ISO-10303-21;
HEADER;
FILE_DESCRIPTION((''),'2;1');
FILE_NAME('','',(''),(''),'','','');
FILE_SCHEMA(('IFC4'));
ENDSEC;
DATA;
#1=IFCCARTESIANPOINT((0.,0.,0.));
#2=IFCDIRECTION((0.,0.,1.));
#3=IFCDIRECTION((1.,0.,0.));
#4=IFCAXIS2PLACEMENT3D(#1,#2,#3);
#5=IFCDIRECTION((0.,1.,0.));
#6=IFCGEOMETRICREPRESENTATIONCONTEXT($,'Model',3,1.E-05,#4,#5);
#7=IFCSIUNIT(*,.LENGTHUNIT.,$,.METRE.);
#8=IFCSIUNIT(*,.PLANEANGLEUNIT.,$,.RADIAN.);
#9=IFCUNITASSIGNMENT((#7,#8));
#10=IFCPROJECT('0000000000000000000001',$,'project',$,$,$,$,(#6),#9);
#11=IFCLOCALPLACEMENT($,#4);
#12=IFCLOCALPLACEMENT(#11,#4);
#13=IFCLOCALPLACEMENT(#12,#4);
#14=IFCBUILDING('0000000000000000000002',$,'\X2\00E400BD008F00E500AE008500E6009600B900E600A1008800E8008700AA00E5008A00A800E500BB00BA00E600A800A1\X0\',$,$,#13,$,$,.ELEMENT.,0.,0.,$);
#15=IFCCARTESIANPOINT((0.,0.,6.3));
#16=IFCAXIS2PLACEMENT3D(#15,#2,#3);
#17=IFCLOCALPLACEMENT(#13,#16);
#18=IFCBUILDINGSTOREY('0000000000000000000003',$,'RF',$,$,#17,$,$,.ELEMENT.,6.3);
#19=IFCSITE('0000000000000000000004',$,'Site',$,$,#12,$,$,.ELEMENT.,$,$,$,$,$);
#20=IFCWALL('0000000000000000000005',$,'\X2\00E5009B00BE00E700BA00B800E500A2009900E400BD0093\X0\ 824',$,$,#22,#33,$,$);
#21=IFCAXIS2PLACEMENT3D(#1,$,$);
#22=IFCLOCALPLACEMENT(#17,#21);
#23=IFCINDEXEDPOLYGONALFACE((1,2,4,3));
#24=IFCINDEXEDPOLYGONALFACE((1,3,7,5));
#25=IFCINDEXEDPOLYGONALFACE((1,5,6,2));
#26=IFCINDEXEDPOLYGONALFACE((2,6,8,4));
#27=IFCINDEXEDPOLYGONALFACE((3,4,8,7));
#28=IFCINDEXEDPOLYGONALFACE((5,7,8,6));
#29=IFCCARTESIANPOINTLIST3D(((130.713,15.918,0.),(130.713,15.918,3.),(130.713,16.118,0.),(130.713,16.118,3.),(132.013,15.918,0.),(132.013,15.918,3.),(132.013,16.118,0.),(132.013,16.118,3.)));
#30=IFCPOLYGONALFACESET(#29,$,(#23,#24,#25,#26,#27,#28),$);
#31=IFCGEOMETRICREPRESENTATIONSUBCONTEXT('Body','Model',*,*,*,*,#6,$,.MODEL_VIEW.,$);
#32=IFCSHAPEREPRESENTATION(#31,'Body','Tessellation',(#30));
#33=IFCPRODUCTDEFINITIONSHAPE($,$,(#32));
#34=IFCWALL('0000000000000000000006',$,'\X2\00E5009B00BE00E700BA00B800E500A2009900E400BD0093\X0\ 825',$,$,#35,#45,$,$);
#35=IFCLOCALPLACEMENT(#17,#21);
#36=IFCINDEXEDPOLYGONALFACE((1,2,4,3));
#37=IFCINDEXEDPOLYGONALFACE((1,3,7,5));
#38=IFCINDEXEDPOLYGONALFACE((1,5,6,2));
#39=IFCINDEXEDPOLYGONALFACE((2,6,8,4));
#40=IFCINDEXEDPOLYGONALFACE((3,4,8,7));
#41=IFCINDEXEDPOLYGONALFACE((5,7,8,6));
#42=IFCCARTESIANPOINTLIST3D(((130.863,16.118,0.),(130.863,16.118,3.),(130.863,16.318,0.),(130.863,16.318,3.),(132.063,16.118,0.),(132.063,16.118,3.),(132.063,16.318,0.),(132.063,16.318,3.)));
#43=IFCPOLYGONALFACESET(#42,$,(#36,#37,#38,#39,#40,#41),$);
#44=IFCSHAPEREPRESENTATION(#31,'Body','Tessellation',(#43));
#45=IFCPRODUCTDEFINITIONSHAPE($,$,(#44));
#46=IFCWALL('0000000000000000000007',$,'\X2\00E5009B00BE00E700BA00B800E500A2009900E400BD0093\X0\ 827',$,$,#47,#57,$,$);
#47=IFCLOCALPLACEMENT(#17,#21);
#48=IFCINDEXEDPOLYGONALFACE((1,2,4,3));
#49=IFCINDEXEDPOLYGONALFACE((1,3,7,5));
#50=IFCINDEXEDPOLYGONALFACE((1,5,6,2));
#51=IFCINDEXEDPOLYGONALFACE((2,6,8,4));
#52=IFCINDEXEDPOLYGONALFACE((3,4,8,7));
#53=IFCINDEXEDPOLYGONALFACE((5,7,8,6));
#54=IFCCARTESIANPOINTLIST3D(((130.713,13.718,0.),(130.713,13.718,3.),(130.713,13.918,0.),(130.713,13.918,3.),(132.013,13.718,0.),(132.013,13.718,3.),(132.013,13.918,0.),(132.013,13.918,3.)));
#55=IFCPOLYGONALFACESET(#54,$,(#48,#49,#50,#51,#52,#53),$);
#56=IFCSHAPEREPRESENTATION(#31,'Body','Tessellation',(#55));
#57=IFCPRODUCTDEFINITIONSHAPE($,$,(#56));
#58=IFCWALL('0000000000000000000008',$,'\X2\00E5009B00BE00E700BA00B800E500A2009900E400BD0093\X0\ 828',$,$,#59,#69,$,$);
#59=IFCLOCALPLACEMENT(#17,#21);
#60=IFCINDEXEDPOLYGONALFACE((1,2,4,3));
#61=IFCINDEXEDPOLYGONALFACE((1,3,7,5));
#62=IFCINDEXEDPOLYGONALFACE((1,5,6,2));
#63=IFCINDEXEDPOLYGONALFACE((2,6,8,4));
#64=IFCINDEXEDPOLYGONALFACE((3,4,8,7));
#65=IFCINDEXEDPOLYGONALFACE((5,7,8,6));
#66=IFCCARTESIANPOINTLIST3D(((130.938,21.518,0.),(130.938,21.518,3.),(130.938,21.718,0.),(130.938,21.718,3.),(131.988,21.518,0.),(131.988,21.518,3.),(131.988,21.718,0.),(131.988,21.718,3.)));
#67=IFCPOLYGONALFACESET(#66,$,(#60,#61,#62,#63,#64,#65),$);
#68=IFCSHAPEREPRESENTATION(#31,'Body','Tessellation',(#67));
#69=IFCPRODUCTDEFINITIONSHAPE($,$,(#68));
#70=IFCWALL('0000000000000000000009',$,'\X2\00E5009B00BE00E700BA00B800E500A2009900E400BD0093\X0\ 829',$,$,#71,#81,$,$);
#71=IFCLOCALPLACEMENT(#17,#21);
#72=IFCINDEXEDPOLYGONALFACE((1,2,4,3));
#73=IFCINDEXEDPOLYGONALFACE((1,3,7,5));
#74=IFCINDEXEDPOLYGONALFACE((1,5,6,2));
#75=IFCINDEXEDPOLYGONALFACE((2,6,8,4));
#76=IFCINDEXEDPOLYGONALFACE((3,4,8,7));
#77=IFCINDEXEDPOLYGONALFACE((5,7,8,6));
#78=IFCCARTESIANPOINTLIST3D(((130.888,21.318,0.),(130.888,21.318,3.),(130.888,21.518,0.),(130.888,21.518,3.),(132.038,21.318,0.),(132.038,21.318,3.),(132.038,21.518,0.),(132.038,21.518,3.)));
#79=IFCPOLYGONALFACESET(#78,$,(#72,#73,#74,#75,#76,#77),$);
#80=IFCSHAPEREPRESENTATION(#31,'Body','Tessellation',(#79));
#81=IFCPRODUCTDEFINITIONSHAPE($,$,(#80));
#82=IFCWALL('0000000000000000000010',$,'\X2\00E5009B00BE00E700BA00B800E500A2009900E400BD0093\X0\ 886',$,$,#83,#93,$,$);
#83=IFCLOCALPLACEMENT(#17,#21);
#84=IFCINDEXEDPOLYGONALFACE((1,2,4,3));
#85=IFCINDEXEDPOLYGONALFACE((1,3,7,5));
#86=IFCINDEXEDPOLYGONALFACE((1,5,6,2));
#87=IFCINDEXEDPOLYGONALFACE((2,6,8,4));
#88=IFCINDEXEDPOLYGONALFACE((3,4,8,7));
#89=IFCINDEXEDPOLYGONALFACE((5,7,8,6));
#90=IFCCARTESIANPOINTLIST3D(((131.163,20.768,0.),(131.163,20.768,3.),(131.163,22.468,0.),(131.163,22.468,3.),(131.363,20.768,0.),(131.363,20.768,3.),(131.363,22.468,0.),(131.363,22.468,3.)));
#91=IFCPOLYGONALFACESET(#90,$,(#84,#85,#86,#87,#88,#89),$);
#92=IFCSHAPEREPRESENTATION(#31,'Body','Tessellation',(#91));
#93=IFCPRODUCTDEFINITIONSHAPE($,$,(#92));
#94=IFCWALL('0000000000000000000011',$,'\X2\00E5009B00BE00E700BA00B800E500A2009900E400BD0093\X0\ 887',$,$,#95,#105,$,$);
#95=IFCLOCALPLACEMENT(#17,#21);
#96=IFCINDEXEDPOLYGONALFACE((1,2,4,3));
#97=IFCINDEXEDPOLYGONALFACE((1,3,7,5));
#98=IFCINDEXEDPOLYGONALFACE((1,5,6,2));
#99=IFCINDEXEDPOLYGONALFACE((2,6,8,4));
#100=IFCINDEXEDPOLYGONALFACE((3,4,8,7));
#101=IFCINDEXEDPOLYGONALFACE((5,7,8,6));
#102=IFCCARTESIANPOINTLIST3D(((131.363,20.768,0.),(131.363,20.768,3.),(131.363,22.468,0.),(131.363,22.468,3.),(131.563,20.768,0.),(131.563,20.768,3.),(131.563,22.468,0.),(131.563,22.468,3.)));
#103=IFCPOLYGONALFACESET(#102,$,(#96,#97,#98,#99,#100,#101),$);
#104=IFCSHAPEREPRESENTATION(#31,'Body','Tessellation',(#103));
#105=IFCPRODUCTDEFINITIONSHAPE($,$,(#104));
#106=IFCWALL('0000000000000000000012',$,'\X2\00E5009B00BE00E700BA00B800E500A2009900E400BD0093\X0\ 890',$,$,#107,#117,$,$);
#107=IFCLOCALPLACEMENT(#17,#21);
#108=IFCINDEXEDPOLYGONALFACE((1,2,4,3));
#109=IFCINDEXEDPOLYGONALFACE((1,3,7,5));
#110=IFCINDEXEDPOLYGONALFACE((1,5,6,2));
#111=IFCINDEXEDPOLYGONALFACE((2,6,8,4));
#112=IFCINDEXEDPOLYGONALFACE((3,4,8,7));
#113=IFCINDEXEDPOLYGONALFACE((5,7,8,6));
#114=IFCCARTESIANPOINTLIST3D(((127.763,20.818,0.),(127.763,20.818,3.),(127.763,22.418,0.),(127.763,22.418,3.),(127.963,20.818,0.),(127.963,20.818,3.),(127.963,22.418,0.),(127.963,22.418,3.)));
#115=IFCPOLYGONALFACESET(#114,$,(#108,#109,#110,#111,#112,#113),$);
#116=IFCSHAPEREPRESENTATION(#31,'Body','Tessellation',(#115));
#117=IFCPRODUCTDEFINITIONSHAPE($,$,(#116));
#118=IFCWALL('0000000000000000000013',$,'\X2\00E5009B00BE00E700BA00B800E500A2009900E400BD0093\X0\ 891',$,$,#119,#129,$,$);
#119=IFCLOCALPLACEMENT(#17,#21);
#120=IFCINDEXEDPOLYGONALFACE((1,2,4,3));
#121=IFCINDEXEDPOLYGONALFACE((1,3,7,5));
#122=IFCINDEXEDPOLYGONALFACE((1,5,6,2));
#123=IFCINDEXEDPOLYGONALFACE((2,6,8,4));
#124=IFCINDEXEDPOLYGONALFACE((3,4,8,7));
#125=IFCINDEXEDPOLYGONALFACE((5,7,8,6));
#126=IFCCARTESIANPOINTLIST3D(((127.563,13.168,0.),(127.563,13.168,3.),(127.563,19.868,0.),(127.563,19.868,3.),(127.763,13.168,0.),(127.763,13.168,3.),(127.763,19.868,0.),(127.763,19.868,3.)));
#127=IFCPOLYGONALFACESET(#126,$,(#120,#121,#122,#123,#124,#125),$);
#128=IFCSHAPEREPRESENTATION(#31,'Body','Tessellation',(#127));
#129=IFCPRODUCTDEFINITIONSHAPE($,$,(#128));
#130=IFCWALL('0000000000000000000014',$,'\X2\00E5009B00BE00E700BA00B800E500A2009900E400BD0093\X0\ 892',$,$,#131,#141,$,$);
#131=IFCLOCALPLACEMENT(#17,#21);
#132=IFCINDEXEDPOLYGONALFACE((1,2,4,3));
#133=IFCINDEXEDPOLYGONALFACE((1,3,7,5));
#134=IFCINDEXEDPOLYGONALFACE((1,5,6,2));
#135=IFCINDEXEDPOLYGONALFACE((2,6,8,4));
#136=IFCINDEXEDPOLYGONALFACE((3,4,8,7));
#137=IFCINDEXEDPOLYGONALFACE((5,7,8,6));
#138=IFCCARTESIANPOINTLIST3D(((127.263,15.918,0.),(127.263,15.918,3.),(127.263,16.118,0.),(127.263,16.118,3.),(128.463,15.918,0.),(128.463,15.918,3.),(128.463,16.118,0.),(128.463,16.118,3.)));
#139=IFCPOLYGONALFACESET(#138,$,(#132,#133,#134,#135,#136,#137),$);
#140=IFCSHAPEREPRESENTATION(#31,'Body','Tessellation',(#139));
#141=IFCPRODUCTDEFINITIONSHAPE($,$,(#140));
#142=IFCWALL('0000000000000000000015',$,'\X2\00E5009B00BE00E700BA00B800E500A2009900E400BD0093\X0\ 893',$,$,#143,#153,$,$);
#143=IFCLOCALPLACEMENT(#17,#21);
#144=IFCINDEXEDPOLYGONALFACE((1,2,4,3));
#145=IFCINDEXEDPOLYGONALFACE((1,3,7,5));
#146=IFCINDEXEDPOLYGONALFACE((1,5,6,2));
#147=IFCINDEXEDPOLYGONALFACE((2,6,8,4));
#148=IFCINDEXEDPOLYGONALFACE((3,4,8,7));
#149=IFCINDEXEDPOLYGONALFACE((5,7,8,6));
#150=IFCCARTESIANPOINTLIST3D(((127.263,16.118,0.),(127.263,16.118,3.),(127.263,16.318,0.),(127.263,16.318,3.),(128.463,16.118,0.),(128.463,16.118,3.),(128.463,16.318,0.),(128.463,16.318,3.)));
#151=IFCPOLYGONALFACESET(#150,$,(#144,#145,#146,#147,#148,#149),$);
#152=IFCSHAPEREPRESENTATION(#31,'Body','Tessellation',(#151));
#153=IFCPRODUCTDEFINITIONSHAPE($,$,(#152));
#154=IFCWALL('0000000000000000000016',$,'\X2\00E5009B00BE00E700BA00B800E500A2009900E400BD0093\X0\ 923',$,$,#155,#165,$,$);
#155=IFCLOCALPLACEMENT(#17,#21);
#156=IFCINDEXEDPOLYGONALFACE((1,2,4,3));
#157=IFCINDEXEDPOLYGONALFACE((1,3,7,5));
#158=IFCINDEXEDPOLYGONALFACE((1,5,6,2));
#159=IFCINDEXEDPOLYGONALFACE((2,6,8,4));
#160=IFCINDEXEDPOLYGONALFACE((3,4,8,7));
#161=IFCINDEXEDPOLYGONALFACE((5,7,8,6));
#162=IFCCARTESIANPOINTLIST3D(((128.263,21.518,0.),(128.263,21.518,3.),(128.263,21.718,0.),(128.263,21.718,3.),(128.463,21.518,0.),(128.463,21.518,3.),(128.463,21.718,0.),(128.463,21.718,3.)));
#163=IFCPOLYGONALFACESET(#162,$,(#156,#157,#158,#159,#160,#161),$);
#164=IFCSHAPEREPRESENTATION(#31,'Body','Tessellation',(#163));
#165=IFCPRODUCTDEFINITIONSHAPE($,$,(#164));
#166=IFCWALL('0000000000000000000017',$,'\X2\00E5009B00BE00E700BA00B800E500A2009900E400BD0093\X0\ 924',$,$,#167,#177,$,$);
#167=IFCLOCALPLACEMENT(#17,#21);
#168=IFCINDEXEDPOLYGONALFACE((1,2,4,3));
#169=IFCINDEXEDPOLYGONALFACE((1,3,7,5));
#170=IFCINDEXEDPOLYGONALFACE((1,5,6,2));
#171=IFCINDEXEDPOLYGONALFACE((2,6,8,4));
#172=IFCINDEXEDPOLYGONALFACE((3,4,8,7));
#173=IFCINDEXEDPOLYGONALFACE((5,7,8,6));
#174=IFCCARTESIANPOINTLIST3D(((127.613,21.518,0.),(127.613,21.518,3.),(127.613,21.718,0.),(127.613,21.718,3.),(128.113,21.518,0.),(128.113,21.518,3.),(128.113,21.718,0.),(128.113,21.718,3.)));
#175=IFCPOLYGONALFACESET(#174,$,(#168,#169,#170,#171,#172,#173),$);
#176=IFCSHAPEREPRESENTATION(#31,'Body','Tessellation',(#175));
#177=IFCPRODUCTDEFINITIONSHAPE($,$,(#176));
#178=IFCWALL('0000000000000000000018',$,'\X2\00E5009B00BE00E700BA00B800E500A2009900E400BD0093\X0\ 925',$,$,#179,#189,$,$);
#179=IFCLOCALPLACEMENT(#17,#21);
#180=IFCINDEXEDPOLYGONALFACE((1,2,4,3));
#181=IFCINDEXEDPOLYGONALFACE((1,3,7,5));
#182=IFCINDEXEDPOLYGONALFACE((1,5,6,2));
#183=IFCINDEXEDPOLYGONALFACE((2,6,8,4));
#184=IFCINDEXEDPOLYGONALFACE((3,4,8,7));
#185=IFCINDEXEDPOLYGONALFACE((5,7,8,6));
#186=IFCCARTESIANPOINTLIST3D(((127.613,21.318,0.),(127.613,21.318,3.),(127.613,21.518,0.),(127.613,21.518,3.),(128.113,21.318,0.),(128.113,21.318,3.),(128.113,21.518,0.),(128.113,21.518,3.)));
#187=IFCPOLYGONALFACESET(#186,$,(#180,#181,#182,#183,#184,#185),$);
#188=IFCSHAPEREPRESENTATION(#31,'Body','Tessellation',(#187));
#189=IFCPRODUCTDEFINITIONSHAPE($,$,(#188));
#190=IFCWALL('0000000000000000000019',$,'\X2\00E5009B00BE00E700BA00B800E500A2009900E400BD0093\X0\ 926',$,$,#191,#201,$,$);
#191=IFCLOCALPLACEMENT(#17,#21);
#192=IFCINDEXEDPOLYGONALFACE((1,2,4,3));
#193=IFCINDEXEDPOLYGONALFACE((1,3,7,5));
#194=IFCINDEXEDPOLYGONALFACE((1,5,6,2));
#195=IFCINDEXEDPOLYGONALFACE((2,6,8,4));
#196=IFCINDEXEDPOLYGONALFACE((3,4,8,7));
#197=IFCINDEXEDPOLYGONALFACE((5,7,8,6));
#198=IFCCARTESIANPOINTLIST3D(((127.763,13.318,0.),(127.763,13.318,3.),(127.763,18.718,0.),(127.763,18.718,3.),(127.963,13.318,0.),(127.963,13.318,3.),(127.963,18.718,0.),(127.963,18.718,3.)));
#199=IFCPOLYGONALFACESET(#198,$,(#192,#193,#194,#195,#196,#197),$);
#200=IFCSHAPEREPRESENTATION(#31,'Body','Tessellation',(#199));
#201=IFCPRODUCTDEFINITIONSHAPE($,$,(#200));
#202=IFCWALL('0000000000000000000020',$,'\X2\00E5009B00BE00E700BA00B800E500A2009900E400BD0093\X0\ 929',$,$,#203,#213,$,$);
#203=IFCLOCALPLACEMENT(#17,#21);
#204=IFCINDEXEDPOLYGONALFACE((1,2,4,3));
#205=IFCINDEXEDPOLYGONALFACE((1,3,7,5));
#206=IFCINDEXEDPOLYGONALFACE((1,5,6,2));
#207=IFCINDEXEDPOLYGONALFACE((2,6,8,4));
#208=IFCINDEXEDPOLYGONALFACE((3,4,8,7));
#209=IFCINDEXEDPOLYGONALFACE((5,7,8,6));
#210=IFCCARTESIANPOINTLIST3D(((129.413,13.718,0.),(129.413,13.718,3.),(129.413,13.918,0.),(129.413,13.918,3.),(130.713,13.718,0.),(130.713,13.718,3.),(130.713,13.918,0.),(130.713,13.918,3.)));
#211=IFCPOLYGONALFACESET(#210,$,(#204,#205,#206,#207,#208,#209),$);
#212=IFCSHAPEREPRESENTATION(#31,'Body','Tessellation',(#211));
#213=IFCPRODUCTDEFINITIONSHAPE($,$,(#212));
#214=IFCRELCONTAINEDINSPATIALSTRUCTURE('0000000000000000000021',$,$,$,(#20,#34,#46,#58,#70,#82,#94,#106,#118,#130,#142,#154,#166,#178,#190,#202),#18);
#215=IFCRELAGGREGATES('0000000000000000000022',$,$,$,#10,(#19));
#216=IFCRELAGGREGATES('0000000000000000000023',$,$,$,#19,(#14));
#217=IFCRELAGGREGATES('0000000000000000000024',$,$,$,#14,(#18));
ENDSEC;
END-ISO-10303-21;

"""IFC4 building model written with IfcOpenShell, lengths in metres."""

from ifc_helpers import new_model, si_unit, direction, frame, frame_2d, origin_with_axes, place, context, subcontext, project, spatial, rectangle, extrude, element, save


model = new_model("IFC4")

# Units and contexts
model_context = context("Model", 3, precision=1e-05, world=origin_with_axes(), true_north=direction((0.0, 1.0, 0.0)))
body_context = subcontext(model_context, "Body", "Model", "MODEL_VIEW")
ifc_project = project(units=[si_unit("LENGTHUNIT", "METRE"), si_unit("PLANEANGLEUNIT", "RADIAN")], contexts=[model_context])

# Site, building, storey
placement = place(None, origin_with_axes())
site_placement = place(placement, origin_with_axes())
site = spatial("IfcSite", under=ifc_project, at=site_placement, Name="Site", CompositionType="ELEMENT")
building_placement = place(site_placement, origin_with_axes())
building = spatial("IfcBuilding", under=site, at=building_placement, Name="ä½\u008få®\u0085æ\u0096¹æ¡\u0088è\u0087ªå\u008a¨å»ºæ¨¡", CompositionType="ELEMENT", ElevationOfRefHeight=0.0, ElevationOfTerrain=0.0)
storey_placement = place(building_placement, frame((0.0, 0.0, 6.3), z_axis=(0.0, 0.0, 1.0), x_axis=(1.0, 0.0, 0.0)))
storey = spatial("IfcBuildingStorey", under=building, at=storey_placement, Name="RF", CompositionType="ELEMENT", Elevation=6.3)

# Walls
wall_1_placement = place(storey_placement, frame((131.363, 16.018, 0.0), z_axis=(0.0, 0.0, 1.0), x_axis=(1.0, 0.0, 0.0)))
element("IfcWall", 1, at=wall_1_placement, inside=storey, Name="å\u009b¾çº¸å¢\u0099ä½\u0093 824", context=body_context, shape_type="SweptSolid", body=[
    extrude(rectangle(XDim=1.3, YDim=0.2, at=frame_2d((0.0, 0.0), x_axis=(1.0, 0.0, 0.0))), frame((0.0, 0.0, 0.0), z_axis=(0.0, 0.0, 1.0)), (0.0, 0.0, 1.0), 3.0),
])
wall_2_placement = place(storey_placement, frame((131.463, 16.218, 0.0), z_axis=(0.0, 0.0, 1.0), x_axis=(1.0, 0.0, 0.0)))
element("IfcWall", 2, at=wall_2_placement, inside=storey, Name="å\u009b¾çº¸å¢\u0099ä½\u0093 825", context=body_context, shape_type="SweptSolid", body=[
    extrude(rectangle(XDim=1.2, YDim=0.2, at=frame_2d((0.0, 0.0), x_axis=(1.0, 0.0, 0.0))), frame((0.0, 0.0, 0.0), z_axis=(0.0, 0.0, 1.0)), (0.0, 0.0, 1.0), 3.0),
])
wall_3_placement = place(storey_placement, frame((131.363, 13.818, 0.0), z_axis=(0.0, 0.0, 1.0), x_axis=(1.0, 0.0, 0.0)))
element("IfcWall", 3, at=wall_3_placement, inside=storey, Name="å\u009b¾çº¸å¢\u0099ä½\u0093 827", context=body_context, shape_type="SweptSolid", body=[
    extrude(rectangle(XDim=1.3, YDim=0.2, at=frame_2d((0.0, 0.0), x_axis=(1.0, 0.0, 0.0))), frame((0.0, 0.0, 0.0), z_axis=(0.0, 0.0, 1.0)), (0.0, 0.0, 1.0), 3.0),
])
wall_4_placement = place(storey_placement, frame((131.463, 21.618, 0.0), z_axis=(0.0, 0.0, 1.0), x_axis=(1.0, 0.0, 0.0)))
element("IfcWall", 4, at=wall_4_placement, inside=storey, Name="å\u009b¾çº¸å¢\u0099ä½\u0093 828", context=body_context, shape_type="SweptSolid", body=[
    extrude(rectangle(XDim=1.05, YDim=0.2, at=frame_2d((0.0, 0.0), x_axis=(1.0, 0.0, 0.0))), frame((0.0, 0.0, 0.0), z_axis=(0.0, 0.0, 1.0)), (0.0, 0.0, 1.0), 3.0),
])
wall_5_placement = place(storey_placement, frame((131.463, 21.418, 0.0), z_axis=(0.0, 0.0, 1.0), x_axis=(1.0, 0.0, 0.0)))
element("IfcWall", 5, at=wall_5_placement, inside=storey, Name="å\u009b¾çº¸å¢\u0099ä½\u0093 829", context=body_context, shape_type="SweptSolid", body=[
    extrude(rectangle(XDim=1.15, YDim=0.2, at=frame_2d((0.0, 0.0), x_axis=(1.0, 0.0, 0.0))), frame((0.0, 0.0, 0.0), z_axis=(0.0, 0.0, 1.0)), (0.0, 0.0, 1.0), 3.0),
])
for number, where, z_axis, x_axis, name in (
    (6, (131.263, 21.618, 0.0), (0.0, 0.0, 1.0), (0.0, 1.0, 0.0), "å\u009b¾çº¸å¢\u0099ä½\u0093 886"),
    (7, (131.463, 21.618, 0.0), (0.0, 0.0, 1.0), (0.0, 1.0, 0.0), "å\u009b¾çº¸å¢\u0099ä½\u0093 887"),
):
    element("IfcWall", number, at=place(storey_placement, frame(where, z_axis=z_axis, x_axis=x_axis)), inside=storey, Name=name, context=body_context, shape_type="SweptSolid", body=[
        extrude(rectangle(XDim=1.7, YDim=0.2, at=frame_2d((0.0, 0.0), x_axis=(1.0, 0.0, 0.0))), frame((0.0, 0.0, 0.0), z_axis=(0.0, 0.0, 1.0)), (0.0, 0.0, 1.0), 3.0),
    ])
wall_6_placement = place(storey_placement, frame((127.863, 21.618, 0.0), z_axis=(0.0, 0.0, 1.0), x_axis=(0.0, 1.0, 0.0)))
element("IfcWall", 8, at=wall_6_placement, inside=storey, Name="å\u009b¾çº¸å¢\u0099ä½\u0093 890", context=body_context, shape_type="SweptSolid", body=[
    extrude(rectangle(XDim=1.6, YDim=0.2, at=frame_2d((0.0, 0.0), x_axis=(1.0, 0.0, 0.0))), frame((0.0, 0.0, 0.0), z_axis=(0.0, 0.0, 1.0)), (0.0, 0.0, 1.0), 3.0),
])
wall_7_placement = place(storey_placement, frame((127.663, 16.518, 0.0), z_axis=(0.0, 0.0, 1.0), x_axis=(0.0, 1.0, 0.0)))
element("IfcWall", 9, at=wall_7_placement, inside=storey, Name="å\u009b¾çº¸å¢\u0099ä½\u0093 891", context=body_context, shape_type="SweptSolid", body=[
    extrude(rectangle(XDim=6.7, YDim=0.2, at=frame_2d((0.0, 0.0), x_axis=(1.0, 0.0, 0.0))), frame((0.0, 0.0, 0.0), z_axis=(0.0, 0.0, 1.0)), (0.0, 0.0, 1.0), 3.0),
])
for number, where, z_axis, x_axis, name in (
    (10, (127.863, 16.018, 0.0), (0.0, 0.0, 1.0), (1.0, 0.0, 0.0), "å\u009b¾çº¸å¢\u0099ä½\u0093 892"),
    (11, (127.863, 16.218, 0.0), (0.0, 0.0, 1.0), (1.0, 0.0, 0.0), "å\u009b¾çº¸å¢\u0099ä½\u0093 893"),
):
    element("IfcWall", number, at=place(storey_placement, frame(where, z_axis=z_axis, x_axis=x_axis)), inside=storey, Name=name, context=body_context, shape_type="SweptSolid", body=[
        extrude(rectangle(XDim=1.2, YDim=0.2, at=frame_2d((0.0, 0.0), x_axis=(1.0, 0.0, 0.0))), frame((0.0, 0.0, 0.0), z_axis=(0.0, 0.0, 1.0)), (0.0, 0.0, 1.0), 3.0),
    ])
wall_8_placement = place(storey_placement, frame((128.363, 21.618, 0.0), z_axis=(0.0, 0.0, 1.0), x_axis=(0.0, -1.0, 0.0)))
element("IfcWall", 12, at=wall_8_placement, inside=storey, Name="å\u009b¾çº¸å¢\u0099ä½\u0093 923", context=body_context, shape_type="SweptSolid", body=[
    extrude(rectangle(XDim=0.2, YDim=0.2, at=frame_2d((0.0, 0.0), x_axis=(1.0, 0.0, 0.0))), frame((0.0, 0.0, 0.0), z_axis=(0.0, 0.0, 1.0)), (0.0, 0.0, 1.0), 3.0),
])
for number, where, z_axis, x_axis, name in (
    (13, (127.863, 21.618, 0.0), (0.0, 0.0, 1.0), (1.0, 0.0, 0.0), "å\u009b¾çº¸å¢\u0099ä½\u0093 924"),
    (14, (127.863, 21.418, 0.0), (0.0, 0.0, 1.0), (1.0, 0.0, 0.0), "å\u009b¾çº¸å¢\u0099ä½\u0093 925"),
):
    element("IfcWall", number, at=place(storey_placement, frame(where, z_axis=z_axis, x_axis=x_axis)), inside=storey, Name=name, context=body_context, shape_type="SweptSolid", body=[
        extrude(rectangle(XDim=0.5, YDim=0.2, at=frame_2d((0.0, 0.0), x_axis=(1.0, 0.0, 0.0))), frame((0.0, 0.0, 0.0), z_axis=(0.0, 0.0, 1.0)), (0.0, 0.0, 1.0), 3.0),
    ])
wall_9_placement = place(storey_placement, frame((127.863, 16.018, 0.0), z_axis=(0.0, 0.0, 1.0), x_axis=(0.0, 1.0, 0.0)))
element("IfcWall", 15, at=wall_9_placement, inside=storey, Name="å\u009b¾çº¸å¢\u0099ä½\u0093 926", context=body_context, shape_type="SweptSolid", body=[
    extrude(rectangle(XDim=5.4, YDim=0.2, at=frame_2d((0.0, 0.0), x_axis=(1.0, 0.0, 0.0))), frame((0.0, 0.0, 0.0), z_axis=(0.0, 0.0, 1.0)), (0.0, 0.0, 1.0), 3.0),
])
wall_10_placement = place(storey_placement, frame((130.063, 13.818, 0.0), z_axis=(0.0, 0.0, 1.0), x_axis=(1.0, 0.0, 0.0)))
element("IfcWall", 16, at=wall_10_placement, inside=storey, Name="å\u009b¾çº¸å¢\u0099ä½\u0093 929", context=body_context, shape_type="SweptSolid", body=[
    extrude(rectangle(XDim=1.3, YDim=0.2, at=frame_2d((0.0, 0.0), x_axis=(1.0, 0.0, 0.0))), frame((0.0, 0.0, 0.0), z_axis=(0.0, 0.0, 1.0)), (0.0, 0.0, 1.0), 3.0),
])

save(model, "model.ifc")
